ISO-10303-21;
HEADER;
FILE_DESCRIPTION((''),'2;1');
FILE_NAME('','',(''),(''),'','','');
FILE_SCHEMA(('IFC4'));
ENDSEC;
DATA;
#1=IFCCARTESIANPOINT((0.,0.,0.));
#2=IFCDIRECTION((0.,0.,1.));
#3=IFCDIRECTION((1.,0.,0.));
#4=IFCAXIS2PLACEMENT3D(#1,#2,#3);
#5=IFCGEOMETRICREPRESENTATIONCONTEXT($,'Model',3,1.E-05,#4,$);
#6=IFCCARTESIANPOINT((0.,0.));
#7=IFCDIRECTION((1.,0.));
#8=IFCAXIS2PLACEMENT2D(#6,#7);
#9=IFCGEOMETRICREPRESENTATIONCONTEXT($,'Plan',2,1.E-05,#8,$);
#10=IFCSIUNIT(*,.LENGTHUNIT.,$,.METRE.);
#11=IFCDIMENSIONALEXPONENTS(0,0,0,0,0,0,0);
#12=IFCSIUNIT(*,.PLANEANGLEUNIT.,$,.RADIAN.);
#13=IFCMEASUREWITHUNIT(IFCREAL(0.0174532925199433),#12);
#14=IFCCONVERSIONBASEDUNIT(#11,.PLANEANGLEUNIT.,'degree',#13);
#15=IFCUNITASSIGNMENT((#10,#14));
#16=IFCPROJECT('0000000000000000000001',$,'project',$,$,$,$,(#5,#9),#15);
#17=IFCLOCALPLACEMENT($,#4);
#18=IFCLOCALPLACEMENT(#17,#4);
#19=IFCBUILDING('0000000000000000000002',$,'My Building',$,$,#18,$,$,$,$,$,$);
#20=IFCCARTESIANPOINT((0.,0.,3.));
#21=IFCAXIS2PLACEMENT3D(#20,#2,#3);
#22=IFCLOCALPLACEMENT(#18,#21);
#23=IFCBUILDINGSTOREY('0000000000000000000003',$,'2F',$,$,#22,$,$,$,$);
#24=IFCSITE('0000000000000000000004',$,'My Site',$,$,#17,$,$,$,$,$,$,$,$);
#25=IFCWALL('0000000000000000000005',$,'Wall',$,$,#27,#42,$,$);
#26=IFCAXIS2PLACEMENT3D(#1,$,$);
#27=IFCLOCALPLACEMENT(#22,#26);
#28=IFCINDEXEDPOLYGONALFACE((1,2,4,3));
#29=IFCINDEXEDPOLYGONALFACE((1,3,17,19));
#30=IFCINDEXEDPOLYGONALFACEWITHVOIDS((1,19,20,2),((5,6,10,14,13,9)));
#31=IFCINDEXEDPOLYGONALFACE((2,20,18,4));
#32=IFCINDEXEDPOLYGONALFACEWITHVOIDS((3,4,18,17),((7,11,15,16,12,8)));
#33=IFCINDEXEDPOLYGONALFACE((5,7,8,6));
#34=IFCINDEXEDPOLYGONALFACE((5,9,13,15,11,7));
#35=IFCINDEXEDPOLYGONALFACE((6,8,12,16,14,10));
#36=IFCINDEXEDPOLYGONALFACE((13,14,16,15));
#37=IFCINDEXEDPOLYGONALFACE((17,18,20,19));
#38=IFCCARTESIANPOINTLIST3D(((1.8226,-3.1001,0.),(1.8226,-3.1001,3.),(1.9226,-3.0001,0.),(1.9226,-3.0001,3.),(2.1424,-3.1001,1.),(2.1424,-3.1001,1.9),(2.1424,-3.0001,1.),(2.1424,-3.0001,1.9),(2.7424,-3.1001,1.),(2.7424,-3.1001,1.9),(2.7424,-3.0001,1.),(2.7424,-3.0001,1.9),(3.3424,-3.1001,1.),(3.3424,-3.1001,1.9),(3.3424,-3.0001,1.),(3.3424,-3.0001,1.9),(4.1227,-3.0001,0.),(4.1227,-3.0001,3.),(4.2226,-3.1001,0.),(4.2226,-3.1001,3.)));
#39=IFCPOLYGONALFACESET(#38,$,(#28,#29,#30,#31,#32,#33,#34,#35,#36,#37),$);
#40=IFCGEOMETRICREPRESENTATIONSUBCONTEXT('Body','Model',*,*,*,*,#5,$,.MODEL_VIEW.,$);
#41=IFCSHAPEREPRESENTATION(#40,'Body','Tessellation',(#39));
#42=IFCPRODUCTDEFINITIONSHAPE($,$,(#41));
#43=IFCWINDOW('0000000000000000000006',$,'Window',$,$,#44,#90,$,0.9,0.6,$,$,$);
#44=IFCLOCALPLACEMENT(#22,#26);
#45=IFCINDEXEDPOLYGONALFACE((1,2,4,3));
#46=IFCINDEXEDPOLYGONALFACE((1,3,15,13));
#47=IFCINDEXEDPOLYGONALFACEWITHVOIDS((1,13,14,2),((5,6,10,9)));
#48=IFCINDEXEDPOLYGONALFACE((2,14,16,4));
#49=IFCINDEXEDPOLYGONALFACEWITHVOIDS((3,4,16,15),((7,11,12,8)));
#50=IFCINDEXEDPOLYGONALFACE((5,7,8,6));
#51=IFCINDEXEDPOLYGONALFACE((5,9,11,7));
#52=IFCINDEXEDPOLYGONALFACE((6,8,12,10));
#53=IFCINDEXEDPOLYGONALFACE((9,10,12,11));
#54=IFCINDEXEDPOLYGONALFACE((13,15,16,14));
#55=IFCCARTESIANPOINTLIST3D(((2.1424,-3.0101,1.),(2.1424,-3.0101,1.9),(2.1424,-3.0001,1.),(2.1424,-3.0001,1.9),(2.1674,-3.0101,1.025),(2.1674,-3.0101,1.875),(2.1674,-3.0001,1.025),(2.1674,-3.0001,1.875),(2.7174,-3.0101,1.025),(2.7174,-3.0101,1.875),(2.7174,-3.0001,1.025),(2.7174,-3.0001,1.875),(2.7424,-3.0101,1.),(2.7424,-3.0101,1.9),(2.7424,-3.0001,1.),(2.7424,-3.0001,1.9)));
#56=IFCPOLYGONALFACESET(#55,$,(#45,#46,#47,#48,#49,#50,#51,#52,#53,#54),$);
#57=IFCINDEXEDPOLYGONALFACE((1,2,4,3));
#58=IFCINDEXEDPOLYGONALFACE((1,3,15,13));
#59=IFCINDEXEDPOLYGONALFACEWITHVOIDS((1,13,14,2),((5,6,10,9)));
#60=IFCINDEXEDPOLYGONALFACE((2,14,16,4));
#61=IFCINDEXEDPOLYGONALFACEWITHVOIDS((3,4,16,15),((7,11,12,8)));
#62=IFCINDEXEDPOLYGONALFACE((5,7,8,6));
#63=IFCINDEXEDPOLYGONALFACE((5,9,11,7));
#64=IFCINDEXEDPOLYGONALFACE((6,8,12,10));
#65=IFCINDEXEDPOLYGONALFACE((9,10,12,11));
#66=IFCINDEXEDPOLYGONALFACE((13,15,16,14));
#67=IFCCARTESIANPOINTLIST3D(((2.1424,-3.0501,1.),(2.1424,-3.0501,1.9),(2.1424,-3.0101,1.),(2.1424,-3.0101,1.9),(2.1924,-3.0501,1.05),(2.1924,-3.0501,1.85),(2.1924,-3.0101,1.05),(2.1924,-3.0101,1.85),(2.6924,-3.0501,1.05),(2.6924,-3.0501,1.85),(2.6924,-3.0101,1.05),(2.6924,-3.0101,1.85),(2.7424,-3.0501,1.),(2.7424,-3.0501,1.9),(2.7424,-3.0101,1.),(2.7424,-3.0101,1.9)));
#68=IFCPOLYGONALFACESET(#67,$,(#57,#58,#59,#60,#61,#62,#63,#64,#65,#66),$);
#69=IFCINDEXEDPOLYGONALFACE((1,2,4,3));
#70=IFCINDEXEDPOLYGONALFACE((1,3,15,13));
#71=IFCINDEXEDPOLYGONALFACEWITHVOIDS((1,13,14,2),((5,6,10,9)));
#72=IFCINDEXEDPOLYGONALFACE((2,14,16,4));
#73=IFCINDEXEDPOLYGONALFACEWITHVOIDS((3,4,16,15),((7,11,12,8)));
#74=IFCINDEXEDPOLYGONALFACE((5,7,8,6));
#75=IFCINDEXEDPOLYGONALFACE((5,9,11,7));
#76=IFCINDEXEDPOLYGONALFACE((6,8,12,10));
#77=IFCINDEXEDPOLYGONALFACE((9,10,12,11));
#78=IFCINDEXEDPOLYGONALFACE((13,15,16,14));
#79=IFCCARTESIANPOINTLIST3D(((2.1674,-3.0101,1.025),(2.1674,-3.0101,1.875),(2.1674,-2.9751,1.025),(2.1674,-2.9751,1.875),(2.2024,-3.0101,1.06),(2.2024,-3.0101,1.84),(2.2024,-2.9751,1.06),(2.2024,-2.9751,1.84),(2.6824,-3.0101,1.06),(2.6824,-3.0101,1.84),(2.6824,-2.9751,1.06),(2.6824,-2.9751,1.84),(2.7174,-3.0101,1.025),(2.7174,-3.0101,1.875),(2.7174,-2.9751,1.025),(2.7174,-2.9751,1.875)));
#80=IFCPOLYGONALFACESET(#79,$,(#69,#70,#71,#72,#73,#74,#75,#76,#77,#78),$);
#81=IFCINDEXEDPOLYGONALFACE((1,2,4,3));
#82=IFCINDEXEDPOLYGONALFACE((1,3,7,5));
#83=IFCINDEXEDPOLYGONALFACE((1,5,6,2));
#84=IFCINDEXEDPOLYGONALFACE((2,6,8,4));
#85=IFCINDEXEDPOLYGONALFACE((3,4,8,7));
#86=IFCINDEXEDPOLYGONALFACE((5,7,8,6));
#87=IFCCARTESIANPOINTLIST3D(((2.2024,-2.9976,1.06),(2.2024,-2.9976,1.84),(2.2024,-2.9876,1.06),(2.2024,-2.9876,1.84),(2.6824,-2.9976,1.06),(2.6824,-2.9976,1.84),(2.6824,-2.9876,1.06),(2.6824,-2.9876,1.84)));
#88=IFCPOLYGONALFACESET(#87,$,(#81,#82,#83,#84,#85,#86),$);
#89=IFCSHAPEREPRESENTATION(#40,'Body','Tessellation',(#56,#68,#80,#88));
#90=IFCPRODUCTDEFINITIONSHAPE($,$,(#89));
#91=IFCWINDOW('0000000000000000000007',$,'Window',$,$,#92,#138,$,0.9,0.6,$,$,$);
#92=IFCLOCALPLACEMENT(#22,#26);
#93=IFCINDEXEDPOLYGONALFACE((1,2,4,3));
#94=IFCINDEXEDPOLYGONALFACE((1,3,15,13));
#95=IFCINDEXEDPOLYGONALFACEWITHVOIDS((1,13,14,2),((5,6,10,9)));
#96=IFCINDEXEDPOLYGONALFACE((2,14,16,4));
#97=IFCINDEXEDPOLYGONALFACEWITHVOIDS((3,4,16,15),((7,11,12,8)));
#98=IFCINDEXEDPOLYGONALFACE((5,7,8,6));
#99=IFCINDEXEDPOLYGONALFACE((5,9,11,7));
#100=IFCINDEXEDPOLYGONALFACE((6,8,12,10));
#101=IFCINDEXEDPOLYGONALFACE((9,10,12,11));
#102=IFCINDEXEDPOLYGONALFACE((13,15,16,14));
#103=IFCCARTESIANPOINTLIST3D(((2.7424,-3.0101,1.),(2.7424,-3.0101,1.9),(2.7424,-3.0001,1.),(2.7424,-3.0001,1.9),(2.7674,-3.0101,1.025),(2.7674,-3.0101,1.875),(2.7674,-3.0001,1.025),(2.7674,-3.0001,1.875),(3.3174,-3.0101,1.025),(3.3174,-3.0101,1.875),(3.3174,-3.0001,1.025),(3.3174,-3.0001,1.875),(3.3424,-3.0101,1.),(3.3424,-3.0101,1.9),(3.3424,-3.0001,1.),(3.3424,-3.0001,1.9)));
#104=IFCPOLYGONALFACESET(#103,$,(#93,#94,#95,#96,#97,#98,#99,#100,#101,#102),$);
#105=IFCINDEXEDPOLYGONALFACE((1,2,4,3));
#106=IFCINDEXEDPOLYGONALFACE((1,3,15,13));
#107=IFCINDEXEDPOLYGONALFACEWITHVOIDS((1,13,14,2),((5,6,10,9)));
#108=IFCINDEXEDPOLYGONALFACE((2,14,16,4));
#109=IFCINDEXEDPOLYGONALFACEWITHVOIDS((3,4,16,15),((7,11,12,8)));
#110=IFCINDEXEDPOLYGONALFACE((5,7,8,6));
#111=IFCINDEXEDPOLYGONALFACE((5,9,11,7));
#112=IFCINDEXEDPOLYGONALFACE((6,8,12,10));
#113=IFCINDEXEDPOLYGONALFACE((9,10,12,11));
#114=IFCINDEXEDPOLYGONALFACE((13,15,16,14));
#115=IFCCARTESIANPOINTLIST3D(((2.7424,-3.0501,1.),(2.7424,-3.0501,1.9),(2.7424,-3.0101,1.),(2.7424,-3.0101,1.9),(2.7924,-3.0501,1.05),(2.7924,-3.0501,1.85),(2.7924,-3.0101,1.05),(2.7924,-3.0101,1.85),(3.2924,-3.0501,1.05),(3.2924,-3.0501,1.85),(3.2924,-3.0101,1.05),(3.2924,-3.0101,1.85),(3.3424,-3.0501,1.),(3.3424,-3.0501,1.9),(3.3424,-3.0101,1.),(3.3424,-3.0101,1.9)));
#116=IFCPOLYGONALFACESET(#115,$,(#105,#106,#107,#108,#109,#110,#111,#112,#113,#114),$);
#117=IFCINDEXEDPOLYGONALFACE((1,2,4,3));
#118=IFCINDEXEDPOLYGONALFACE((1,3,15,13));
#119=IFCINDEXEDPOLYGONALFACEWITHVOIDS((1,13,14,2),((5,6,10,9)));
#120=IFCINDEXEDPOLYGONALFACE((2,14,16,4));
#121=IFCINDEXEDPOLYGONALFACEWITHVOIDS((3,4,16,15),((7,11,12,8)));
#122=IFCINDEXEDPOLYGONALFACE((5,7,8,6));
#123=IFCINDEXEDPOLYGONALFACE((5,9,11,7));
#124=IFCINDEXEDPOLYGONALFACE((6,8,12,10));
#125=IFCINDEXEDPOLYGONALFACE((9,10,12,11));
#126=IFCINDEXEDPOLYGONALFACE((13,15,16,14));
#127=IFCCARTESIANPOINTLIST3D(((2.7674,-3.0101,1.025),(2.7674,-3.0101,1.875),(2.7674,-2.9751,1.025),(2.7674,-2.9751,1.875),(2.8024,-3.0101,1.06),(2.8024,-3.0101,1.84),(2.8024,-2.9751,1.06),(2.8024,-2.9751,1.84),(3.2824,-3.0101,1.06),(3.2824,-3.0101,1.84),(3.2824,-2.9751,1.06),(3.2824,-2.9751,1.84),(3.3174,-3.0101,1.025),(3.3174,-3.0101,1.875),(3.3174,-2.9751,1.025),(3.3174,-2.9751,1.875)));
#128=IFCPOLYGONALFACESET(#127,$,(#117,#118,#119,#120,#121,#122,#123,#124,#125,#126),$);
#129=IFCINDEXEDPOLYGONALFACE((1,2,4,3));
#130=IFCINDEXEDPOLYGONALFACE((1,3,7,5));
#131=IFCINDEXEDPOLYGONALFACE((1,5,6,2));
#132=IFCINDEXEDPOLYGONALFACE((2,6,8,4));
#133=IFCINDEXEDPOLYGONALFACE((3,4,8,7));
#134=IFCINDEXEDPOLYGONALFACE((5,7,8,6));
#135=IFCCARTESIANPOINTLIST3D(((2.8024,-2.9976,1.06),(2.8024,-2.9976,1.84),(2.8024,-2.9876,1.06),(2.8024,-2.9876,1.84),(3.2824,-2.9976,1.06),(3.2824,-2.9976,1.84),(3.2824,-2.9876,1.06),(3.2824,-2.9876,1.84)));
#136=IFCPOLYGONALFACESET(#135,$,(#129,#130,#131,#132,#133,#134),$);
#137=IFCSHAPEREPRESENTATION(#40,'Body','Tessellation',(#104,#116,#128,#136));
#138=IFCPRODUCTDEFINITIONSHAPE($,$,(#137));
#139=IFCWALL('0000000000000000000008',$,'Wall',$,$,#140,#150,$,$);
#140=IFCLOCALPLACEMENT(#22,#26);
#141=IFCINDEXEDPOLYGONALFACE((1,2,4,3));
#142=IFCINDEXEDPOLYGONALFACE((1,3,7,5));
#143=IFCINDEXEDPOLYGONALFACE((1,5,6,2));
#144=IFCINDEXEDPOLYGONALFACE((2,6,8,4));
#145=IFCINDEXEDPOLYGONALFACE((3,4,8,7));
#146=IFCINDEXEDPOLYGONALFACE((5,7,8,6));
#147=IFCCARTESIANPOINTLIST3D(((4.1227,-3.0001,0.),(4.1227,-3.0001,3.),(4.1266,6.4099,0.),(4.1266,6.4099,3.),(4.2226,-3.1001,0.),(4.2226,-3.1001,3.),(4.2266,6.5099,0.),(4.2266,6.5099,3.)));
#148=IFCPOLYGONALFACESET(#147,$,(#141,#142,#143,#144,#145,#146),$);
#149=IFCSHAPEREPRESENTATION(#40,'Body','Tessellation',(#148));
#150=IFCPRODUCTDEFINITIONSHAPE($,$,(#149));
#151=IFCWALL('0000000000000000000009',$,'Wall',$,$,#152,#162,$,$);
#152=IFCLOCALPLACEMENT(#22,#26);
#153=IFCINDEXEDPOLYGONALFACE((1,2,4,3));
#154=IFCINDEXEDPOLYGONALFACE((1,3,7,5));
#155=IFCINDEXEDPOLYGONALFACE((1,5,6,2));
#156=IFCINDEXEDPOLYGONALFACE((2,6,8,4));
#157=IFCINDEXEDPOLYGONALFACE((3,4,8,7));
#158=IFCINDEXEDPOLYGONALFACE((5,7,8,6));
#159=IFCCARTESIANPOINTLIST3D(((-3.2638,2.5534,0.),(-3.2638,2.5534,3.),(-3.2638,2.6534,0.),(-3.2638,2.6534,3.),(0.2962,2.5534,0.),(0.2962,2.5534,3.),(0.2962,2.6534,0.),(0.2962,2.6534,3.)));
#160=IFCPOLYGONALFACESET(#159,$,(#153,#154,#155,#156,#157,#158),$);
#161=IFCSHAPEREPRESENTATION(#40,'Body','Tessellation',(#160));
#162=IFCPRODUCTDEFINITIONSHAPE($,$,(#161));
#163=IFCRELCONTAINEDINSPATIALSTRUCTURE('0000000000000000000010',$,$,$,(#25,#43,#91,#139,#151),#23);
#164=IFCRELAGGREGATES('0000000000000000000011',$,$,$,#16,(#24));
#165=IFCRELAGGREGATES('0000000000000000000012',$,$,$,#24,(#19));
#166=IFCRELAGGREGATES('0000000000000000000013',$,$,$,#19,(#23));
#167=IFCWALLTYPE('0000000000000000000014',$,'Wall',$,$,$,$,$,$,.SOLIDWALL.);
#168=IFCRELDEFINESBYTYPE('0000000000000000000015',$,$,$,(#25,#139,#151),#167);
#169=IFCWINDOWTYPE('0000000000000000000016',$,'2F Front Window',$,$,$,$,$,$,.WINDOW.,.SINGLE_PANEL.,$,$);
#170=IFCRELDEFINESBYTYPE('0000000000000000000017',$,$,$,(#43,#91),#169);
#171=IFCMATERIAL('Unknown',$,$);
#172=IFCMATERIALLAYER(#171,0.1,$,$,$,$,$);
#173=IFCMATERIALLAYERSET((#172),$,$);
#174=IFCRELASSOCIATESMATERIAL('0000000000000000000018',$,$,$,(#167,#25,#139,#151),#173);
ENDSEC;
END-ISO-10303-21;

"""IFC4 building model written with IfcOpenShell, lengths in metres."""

from ifc_helpers import new_model, entity, si_unit, converted_unit, frame, origin_with_axes, origin_2d_with_axis, place, context, subcontext, project, spatial, line, indexed_curve, outline, extrude, shape, source, transform, mapped, material, layer, layer_set, layer_usage, type_object, type_shapes, element, fill, save


model = new_model("IFC4")

# Units and contexts
model_context = context("Model", 3, precision=1e-05, world=origin_with_axes())
plan_context = context("Plan", 2, precision=1e-05, world=origin_2d_with_axis())
body_context_1 = subcontext(model_context, "Body", "Model", "MODEL_VIEW")
body_context_2 = subcontext(plan_context, "Body", "Plan", "PLAN_VIEW")
ifc_project = project(units=[si_unit("LENGTHUNIT", "METRE"), converted_unit("PLANEANGLEUNIT", "degree", entity("IfcReal", 0.0174532925199433), si_unit("PLANEANGLEUNIT", "RADIAN"), dimensions=[0, 0, 0, 0, 0, 0, 0])], contexts=[model_context, plan_context])

# Site, building, storey
site_placement = place(None, origin_with_axes())
site = spatial("IfcSite", under=ifc_project, at=site_placement, Name="My Site")
building_placement = place(site_placement, origin_with_axes())
building = spatial("IfcBuilding", under=site, at=building_placement, Name="My Building")
storey_placement = place(building_placement, frame((0.0, 0.0, 3.0), z_axis=(0.0, 0.0, 1.0), x_axis=(1.0, 0.0, 0.0)))
storey = spatial("IfcBuildingStorey", under=building, at=storey_placement, Name="2F")

# Shared definitions
ifc_material = material(Name="Unknown")

# Wall, openings, windows
ifc_layer_1 = layer(ifc_material, 0.1)
ifc_layer_set_1 = layer_set([ifc_layer_1])
ifc_layer_usage_1 = layer_usage(ifc_layer_set_1, "AXIS2", "POSITIVE", 0.0)
wall_type = type_object("IfcWallType", Name="Wall", PredefinedType="SOLIDWALL", material=ifc_layer_set_1)
wall_1_placement = place(storey_placement, frame((1.8226, -3.1001, 0.0), z_axis=(0.0, 0.0, 1.0), x_axis=(1.0, 0.0, 0.0)))
wall_1 = element("IfcWall", 1, at=wall_1_placement, inside=storey, type_object=wall_type, material=ifc_layer_usage_1, Name="Wall", context=body_context_1, shape_type="SweptSolid", body=[
    extrude(outline(indexed_curve([(0.0, 0.0), (0.1, 0.1), (2.3, 0.1), (2.4, 0.0)], segments=[line(1, 2, 3, 4, 1)])), origin_with_axes(), (0.0, 0.0, 1.0), 3.0),
])
shared_shape_1 = source(origin_with_axes(), body_context_1, "Body", "SweptSolid", [
    extrude(outline(indexed_curve([(0.0, 0.0), (0.6, 0.0), (0.6, 0.9), (0.0, 0.9)], segments=[line(1, 2, 3, 4, 1)])), frame((0.0, -0.6, 0.0), z_axis=(0.0, -1.0, 0.0), x_axis=(1.0, 0.0, 0.0)), (0.0, 0.0, -1.0), 1.2),
])
opening_1_placement = place(wall_1_placement, frame((0.3197, 0.0, 1.0), z_axis=(0.0, 0.0, 1.0), x_axis=(1.0, 0.0, 0.0)))
opening_1 = element("IfcOpeningElement", 2, at=opening_1_placement, cuts=wall_1, PredefinedType="OPENING", context=body_context_1, shape_type="MappedRepresentation", body=[
    mapped(shared_shape_1, transform((0.0, 0.0, 0.0), x_axis=(1.0, 0.0, 0.0), y_axis=(0.0, 1.0, 0.0), z_axis=(0.0, 0.0, 1.0), scale=1.0)),
])
opening_2_placement = place(wall_1_placement, frame((0.9197, 0.0, 1.0), z_axis=(0.0, 0.0, 1.0), x_axis=(1.0, 0.0, 0.0)))
opening_2 = element("IfcOpeningElement", 3, at=opening_2_placement, cuts=wall_1, PredefinedType="OPENING", context=body_context_1, shape_type="MappedRepresentation", body=[
    mapped(shared_shape_1, transform((0.0, 0.0, 0.0), x_axis=(1.0, 0.0, 0.0), y_axis=(0.0, 1.0, 0.0), z_axis=(0.0, 0.0, 1.0), scale=1.0)),
])
window_type = type_object("IfcWindowType", Name="2F Front Window", PartitioningType="SINGLE_PANEL", PredefinedType="WINDOW")
shared_shape_2 = source(origin_with_axes(), body_context_1, "Body", "SweptSolid", [
    extrude(outline(indexed_curve([(0.0, 0.0), (0.6, 0.0), (0.6, 0.9), (0.0, 0.9)], segments=[line(1, 2, 3, 4, 1)]), holes=[indexed_curve([(0.025, 0.025), (0.575, 0.025), (0.575, 0.875), (0.025, 0.875)], segments=[line(1, 2, 3, 4, 1)])]), frame((0.0, 0.09, 0.0), z_axis=(0.0, -1.0, 0.0), x_axis=(1.0, 0.0, 0.0)), (0.0, 0.0, -1.0), 0.01),
    extrude(outline(indexed_curve([(0.0, 0.0), (0.6, 0.0), (0.6, 0.9), (0.0, 0.9)], segments=[line(1, 2, 3, 4, 1)]), holes=[indexed_curve([(0.05, 0.05), (0.55, 0.05), (0.55, 0.85), (0.05, 0.85)], segments=[line(1, 2, 3, 4, 1)])]), frame((0.0, 0.05, 0.0), z_axis=(0.0, -1.0, 0.0), x_axis=(1.0, 0.0, 0.0)), (0.0, 0.0, -1.0), 0.04),
    extrude(outline(indexed_curve([(0.0, 0.0), (0.55, 0.0), (0.55, 0.85), (0.0, 0.85)], segments=[line(1, 2, 3, 4, 1)]), holes=[indexed_curve([(0.035, 0.035), (0.515, 0.035), (0.515, 0.815), (0.035, 0.815)], segments=[line(1, 2, 3, 4, 1)])]), frame((0.025, 0.09, 0.025), z_axis=(0.0, -1.0, 0.0), x_axis=(1.0, 0.0, 0.0)), (0.0, 0.0, -1.0), 0.035),
    extrude(outline(indexed_curve([(0.035, 0.035), (0.515, 0.035), (0.515, 0.815), (0.035, 0.815)], segments=[line(1, 2, 3, 4, 1)])), frame((0.025, 0.1025, 0.025), z_axis=(0.0, -1.0, 0.0), x_axis=(1.0, 0.0, 0.0)), (0.0, 0.0, -1.0), 0.01),
])
shared_shape_3 = source(origin_with_axes(), body_context_2, "Body", "Curve2D", [
    entity("IfcIndexedPolyCurve", entity("IfcCartesianPointList2D", [[0.05, 0.05], [0.55, 0.05]])),
    entity("IfcIndexedPolyCurve", entity("IfcCartesianPointList2D", [[0.0, 0.1], [0.025, 0.1], [0.025, 0.09], [0.05, 0.09], [0.05, 0.05], [0.0, 0.05]]), [entity("IfcLineIndex", [1, 2, 3, 4, 5, 6, 1])]),
    entity("IfcIndexedPolyCurve", entity("IfcCartesianPointList2D", [[0.6, 0.1], [0.575, 0.1], [0.575, 0.09], [0.55, 0.09], [0.55, 0.05], [0.6, 0.05]]), [entity("IfcLineIndex", [1, 2, 3, 4, 5, 6, 1])]),
    entity("IfcIndexedPolyCurve", entity("IfcCartesianPointList2D", [[0.025, 0.09], [0.06, 0.09], [0.06, 0.125], [0.025, 0.125]]), [entity("IfcLineIndex", [1, 2, 3, 4, 1])]),
    entity("IfcIndexedPolyCurve", entity("IfcCartesianPointList2D", [[0.575, 0.09], [0.54, 0.09], [0.54, 0.125], [0.575, 0.125]]), [entity("IfcLineIndex", [1, 2, 3, 4, 1])]),
    entity("IfcIndexedPolyCurve", entity("IfcCartesianPointList2D", [[0.06, 0.09], [0.54, 0.09]])),
    entity("IfcIndexedPolyCurve", entity("IfcCartesianPointList2D", [[0.06, 0.125], [0.54, 0.125]])),
    entity("IfcIndexedPolyCurve", entity("IfcCartesianPointList2D", [[0.06, 0.1075], [0.54, 0.1075]])),
])
type_shapes(window_type, [shared_shape_2, shared_shape_3])
window_1_placement = place(opening_1_placement, origin_with_axes())
window_1 = element("IfcWindow", 4, at=window_1_placement, inside=storey, type_object=window_type, Name="Window", OverallHeight=0.9, OverallWidth=0.6, shapes=[
    shape(body_context_1, "Body", "MappedRepresentation", [mapped(shared_shape_2, transform((0.0, 0.0, 0.0), x_axis=(1.0, 0.0, 0.0), y_axis=(0.0, 1.0, 0.0), z_axis=(0.0, 0.0, 1.0), scale=1.0))]),
    shape(body_context_2, "Body", "MappedRepresentation", [mapped(shared_shape_3, transform((0.0, 0.0, 0.0), x_axis=(1.0, 0.0, 0.0), y_axis=(0.0, 1.0, 0.0), z_axis=(0.0, 0.0, 1.0), scale=1.0))]),
])
fill(opening_1, window_1)
window_2_placement = place(opening_2_placement, origin_with_axes())
window_2 = element("IfcWindow", 5, at=window_2_placement, inside=storey, type_object=window_type, Name="Window", OverallHeight=0.9, OverallWidth=0.6, shapes=[
    shape(body_context_1, "Body", "MappedRepresentation", [mapped(shared_shape_2, transform((0.0, 0.0, 0.0), x_axis=(1.0, 0.0, 0.0), y_axis=(0.0, 1.0, 0.0), z_axis=(0.0, 0.0, 1.0), scale=1.0))]),
    shape(body_context_2, "Body", "MappedRepresentation", [mapped(shared_shape_3, transform((0.0, 0.0, 0.0), x_axis=(1.0, 0.0, 0.0), y_axis=(0.0, 1.0, 0.0), z_axis=(0.0, 0.0, 1.0), scale=1.0))]),
])
fill(opening_2, window_2)

# Walls
ifc_layer_usage_2 = layer_usage(ifc_layer_set_1, "AXIS2", "POSITIVE", 0.0)
wall_2_placement = place(storey_placement, frame((4.2226, -3.1001, 0.0), z_axis=(0.0, 0.0, 1.0), x_axis=(0.000415, 1.0, 0.0)))
element("IfcWall", 6, at=wall_2_placement, inside=storey, type_object=wall_type, material=ifc_layer_usage_2, Name="Wall", context=body_context_1, shape_type="SweptSolid", body=[
    extrude(outline(indexed_curve([(0.0, 0.0), (0.1, 0.1), (9.51, 0.1), (9.61, 0.0)], segments=[line(1, 2, 3, 4, 1)])), origin_with_axes(), (0.0, 0.0, 1.0), 3.0),
])
ifc_layer_usage_3 = layer_usage(ifc_layer_set_1, "AXIS2", "POSITIVE", 0.0)
wall_3_placement = place(storey_placement, frame((-3.2638, 2.5534, 0.0), z_axis=(0.0, 0.0, 1.0), x_axis=(1.0, 0.0, 0.0)))
element("IfcWall", 7, at=wall_3_placement, inside=storey, type_object=wall_type, material=ifc_layer_usage_3, Name="Wall", context=body_context_1, shape_type="SweptSolid", body=[
    extrude(outline(indexed_curve([(0.0, 0.0), (0.0, 0.1), (3.56, 0.1), (3.56, 0.0)], segments=[line(1, 2, 3, 4, 1)])), origin_with_axes(), (0.0, 0.0, 1.0), 3.0),
])

save(model, "model.ifc")
